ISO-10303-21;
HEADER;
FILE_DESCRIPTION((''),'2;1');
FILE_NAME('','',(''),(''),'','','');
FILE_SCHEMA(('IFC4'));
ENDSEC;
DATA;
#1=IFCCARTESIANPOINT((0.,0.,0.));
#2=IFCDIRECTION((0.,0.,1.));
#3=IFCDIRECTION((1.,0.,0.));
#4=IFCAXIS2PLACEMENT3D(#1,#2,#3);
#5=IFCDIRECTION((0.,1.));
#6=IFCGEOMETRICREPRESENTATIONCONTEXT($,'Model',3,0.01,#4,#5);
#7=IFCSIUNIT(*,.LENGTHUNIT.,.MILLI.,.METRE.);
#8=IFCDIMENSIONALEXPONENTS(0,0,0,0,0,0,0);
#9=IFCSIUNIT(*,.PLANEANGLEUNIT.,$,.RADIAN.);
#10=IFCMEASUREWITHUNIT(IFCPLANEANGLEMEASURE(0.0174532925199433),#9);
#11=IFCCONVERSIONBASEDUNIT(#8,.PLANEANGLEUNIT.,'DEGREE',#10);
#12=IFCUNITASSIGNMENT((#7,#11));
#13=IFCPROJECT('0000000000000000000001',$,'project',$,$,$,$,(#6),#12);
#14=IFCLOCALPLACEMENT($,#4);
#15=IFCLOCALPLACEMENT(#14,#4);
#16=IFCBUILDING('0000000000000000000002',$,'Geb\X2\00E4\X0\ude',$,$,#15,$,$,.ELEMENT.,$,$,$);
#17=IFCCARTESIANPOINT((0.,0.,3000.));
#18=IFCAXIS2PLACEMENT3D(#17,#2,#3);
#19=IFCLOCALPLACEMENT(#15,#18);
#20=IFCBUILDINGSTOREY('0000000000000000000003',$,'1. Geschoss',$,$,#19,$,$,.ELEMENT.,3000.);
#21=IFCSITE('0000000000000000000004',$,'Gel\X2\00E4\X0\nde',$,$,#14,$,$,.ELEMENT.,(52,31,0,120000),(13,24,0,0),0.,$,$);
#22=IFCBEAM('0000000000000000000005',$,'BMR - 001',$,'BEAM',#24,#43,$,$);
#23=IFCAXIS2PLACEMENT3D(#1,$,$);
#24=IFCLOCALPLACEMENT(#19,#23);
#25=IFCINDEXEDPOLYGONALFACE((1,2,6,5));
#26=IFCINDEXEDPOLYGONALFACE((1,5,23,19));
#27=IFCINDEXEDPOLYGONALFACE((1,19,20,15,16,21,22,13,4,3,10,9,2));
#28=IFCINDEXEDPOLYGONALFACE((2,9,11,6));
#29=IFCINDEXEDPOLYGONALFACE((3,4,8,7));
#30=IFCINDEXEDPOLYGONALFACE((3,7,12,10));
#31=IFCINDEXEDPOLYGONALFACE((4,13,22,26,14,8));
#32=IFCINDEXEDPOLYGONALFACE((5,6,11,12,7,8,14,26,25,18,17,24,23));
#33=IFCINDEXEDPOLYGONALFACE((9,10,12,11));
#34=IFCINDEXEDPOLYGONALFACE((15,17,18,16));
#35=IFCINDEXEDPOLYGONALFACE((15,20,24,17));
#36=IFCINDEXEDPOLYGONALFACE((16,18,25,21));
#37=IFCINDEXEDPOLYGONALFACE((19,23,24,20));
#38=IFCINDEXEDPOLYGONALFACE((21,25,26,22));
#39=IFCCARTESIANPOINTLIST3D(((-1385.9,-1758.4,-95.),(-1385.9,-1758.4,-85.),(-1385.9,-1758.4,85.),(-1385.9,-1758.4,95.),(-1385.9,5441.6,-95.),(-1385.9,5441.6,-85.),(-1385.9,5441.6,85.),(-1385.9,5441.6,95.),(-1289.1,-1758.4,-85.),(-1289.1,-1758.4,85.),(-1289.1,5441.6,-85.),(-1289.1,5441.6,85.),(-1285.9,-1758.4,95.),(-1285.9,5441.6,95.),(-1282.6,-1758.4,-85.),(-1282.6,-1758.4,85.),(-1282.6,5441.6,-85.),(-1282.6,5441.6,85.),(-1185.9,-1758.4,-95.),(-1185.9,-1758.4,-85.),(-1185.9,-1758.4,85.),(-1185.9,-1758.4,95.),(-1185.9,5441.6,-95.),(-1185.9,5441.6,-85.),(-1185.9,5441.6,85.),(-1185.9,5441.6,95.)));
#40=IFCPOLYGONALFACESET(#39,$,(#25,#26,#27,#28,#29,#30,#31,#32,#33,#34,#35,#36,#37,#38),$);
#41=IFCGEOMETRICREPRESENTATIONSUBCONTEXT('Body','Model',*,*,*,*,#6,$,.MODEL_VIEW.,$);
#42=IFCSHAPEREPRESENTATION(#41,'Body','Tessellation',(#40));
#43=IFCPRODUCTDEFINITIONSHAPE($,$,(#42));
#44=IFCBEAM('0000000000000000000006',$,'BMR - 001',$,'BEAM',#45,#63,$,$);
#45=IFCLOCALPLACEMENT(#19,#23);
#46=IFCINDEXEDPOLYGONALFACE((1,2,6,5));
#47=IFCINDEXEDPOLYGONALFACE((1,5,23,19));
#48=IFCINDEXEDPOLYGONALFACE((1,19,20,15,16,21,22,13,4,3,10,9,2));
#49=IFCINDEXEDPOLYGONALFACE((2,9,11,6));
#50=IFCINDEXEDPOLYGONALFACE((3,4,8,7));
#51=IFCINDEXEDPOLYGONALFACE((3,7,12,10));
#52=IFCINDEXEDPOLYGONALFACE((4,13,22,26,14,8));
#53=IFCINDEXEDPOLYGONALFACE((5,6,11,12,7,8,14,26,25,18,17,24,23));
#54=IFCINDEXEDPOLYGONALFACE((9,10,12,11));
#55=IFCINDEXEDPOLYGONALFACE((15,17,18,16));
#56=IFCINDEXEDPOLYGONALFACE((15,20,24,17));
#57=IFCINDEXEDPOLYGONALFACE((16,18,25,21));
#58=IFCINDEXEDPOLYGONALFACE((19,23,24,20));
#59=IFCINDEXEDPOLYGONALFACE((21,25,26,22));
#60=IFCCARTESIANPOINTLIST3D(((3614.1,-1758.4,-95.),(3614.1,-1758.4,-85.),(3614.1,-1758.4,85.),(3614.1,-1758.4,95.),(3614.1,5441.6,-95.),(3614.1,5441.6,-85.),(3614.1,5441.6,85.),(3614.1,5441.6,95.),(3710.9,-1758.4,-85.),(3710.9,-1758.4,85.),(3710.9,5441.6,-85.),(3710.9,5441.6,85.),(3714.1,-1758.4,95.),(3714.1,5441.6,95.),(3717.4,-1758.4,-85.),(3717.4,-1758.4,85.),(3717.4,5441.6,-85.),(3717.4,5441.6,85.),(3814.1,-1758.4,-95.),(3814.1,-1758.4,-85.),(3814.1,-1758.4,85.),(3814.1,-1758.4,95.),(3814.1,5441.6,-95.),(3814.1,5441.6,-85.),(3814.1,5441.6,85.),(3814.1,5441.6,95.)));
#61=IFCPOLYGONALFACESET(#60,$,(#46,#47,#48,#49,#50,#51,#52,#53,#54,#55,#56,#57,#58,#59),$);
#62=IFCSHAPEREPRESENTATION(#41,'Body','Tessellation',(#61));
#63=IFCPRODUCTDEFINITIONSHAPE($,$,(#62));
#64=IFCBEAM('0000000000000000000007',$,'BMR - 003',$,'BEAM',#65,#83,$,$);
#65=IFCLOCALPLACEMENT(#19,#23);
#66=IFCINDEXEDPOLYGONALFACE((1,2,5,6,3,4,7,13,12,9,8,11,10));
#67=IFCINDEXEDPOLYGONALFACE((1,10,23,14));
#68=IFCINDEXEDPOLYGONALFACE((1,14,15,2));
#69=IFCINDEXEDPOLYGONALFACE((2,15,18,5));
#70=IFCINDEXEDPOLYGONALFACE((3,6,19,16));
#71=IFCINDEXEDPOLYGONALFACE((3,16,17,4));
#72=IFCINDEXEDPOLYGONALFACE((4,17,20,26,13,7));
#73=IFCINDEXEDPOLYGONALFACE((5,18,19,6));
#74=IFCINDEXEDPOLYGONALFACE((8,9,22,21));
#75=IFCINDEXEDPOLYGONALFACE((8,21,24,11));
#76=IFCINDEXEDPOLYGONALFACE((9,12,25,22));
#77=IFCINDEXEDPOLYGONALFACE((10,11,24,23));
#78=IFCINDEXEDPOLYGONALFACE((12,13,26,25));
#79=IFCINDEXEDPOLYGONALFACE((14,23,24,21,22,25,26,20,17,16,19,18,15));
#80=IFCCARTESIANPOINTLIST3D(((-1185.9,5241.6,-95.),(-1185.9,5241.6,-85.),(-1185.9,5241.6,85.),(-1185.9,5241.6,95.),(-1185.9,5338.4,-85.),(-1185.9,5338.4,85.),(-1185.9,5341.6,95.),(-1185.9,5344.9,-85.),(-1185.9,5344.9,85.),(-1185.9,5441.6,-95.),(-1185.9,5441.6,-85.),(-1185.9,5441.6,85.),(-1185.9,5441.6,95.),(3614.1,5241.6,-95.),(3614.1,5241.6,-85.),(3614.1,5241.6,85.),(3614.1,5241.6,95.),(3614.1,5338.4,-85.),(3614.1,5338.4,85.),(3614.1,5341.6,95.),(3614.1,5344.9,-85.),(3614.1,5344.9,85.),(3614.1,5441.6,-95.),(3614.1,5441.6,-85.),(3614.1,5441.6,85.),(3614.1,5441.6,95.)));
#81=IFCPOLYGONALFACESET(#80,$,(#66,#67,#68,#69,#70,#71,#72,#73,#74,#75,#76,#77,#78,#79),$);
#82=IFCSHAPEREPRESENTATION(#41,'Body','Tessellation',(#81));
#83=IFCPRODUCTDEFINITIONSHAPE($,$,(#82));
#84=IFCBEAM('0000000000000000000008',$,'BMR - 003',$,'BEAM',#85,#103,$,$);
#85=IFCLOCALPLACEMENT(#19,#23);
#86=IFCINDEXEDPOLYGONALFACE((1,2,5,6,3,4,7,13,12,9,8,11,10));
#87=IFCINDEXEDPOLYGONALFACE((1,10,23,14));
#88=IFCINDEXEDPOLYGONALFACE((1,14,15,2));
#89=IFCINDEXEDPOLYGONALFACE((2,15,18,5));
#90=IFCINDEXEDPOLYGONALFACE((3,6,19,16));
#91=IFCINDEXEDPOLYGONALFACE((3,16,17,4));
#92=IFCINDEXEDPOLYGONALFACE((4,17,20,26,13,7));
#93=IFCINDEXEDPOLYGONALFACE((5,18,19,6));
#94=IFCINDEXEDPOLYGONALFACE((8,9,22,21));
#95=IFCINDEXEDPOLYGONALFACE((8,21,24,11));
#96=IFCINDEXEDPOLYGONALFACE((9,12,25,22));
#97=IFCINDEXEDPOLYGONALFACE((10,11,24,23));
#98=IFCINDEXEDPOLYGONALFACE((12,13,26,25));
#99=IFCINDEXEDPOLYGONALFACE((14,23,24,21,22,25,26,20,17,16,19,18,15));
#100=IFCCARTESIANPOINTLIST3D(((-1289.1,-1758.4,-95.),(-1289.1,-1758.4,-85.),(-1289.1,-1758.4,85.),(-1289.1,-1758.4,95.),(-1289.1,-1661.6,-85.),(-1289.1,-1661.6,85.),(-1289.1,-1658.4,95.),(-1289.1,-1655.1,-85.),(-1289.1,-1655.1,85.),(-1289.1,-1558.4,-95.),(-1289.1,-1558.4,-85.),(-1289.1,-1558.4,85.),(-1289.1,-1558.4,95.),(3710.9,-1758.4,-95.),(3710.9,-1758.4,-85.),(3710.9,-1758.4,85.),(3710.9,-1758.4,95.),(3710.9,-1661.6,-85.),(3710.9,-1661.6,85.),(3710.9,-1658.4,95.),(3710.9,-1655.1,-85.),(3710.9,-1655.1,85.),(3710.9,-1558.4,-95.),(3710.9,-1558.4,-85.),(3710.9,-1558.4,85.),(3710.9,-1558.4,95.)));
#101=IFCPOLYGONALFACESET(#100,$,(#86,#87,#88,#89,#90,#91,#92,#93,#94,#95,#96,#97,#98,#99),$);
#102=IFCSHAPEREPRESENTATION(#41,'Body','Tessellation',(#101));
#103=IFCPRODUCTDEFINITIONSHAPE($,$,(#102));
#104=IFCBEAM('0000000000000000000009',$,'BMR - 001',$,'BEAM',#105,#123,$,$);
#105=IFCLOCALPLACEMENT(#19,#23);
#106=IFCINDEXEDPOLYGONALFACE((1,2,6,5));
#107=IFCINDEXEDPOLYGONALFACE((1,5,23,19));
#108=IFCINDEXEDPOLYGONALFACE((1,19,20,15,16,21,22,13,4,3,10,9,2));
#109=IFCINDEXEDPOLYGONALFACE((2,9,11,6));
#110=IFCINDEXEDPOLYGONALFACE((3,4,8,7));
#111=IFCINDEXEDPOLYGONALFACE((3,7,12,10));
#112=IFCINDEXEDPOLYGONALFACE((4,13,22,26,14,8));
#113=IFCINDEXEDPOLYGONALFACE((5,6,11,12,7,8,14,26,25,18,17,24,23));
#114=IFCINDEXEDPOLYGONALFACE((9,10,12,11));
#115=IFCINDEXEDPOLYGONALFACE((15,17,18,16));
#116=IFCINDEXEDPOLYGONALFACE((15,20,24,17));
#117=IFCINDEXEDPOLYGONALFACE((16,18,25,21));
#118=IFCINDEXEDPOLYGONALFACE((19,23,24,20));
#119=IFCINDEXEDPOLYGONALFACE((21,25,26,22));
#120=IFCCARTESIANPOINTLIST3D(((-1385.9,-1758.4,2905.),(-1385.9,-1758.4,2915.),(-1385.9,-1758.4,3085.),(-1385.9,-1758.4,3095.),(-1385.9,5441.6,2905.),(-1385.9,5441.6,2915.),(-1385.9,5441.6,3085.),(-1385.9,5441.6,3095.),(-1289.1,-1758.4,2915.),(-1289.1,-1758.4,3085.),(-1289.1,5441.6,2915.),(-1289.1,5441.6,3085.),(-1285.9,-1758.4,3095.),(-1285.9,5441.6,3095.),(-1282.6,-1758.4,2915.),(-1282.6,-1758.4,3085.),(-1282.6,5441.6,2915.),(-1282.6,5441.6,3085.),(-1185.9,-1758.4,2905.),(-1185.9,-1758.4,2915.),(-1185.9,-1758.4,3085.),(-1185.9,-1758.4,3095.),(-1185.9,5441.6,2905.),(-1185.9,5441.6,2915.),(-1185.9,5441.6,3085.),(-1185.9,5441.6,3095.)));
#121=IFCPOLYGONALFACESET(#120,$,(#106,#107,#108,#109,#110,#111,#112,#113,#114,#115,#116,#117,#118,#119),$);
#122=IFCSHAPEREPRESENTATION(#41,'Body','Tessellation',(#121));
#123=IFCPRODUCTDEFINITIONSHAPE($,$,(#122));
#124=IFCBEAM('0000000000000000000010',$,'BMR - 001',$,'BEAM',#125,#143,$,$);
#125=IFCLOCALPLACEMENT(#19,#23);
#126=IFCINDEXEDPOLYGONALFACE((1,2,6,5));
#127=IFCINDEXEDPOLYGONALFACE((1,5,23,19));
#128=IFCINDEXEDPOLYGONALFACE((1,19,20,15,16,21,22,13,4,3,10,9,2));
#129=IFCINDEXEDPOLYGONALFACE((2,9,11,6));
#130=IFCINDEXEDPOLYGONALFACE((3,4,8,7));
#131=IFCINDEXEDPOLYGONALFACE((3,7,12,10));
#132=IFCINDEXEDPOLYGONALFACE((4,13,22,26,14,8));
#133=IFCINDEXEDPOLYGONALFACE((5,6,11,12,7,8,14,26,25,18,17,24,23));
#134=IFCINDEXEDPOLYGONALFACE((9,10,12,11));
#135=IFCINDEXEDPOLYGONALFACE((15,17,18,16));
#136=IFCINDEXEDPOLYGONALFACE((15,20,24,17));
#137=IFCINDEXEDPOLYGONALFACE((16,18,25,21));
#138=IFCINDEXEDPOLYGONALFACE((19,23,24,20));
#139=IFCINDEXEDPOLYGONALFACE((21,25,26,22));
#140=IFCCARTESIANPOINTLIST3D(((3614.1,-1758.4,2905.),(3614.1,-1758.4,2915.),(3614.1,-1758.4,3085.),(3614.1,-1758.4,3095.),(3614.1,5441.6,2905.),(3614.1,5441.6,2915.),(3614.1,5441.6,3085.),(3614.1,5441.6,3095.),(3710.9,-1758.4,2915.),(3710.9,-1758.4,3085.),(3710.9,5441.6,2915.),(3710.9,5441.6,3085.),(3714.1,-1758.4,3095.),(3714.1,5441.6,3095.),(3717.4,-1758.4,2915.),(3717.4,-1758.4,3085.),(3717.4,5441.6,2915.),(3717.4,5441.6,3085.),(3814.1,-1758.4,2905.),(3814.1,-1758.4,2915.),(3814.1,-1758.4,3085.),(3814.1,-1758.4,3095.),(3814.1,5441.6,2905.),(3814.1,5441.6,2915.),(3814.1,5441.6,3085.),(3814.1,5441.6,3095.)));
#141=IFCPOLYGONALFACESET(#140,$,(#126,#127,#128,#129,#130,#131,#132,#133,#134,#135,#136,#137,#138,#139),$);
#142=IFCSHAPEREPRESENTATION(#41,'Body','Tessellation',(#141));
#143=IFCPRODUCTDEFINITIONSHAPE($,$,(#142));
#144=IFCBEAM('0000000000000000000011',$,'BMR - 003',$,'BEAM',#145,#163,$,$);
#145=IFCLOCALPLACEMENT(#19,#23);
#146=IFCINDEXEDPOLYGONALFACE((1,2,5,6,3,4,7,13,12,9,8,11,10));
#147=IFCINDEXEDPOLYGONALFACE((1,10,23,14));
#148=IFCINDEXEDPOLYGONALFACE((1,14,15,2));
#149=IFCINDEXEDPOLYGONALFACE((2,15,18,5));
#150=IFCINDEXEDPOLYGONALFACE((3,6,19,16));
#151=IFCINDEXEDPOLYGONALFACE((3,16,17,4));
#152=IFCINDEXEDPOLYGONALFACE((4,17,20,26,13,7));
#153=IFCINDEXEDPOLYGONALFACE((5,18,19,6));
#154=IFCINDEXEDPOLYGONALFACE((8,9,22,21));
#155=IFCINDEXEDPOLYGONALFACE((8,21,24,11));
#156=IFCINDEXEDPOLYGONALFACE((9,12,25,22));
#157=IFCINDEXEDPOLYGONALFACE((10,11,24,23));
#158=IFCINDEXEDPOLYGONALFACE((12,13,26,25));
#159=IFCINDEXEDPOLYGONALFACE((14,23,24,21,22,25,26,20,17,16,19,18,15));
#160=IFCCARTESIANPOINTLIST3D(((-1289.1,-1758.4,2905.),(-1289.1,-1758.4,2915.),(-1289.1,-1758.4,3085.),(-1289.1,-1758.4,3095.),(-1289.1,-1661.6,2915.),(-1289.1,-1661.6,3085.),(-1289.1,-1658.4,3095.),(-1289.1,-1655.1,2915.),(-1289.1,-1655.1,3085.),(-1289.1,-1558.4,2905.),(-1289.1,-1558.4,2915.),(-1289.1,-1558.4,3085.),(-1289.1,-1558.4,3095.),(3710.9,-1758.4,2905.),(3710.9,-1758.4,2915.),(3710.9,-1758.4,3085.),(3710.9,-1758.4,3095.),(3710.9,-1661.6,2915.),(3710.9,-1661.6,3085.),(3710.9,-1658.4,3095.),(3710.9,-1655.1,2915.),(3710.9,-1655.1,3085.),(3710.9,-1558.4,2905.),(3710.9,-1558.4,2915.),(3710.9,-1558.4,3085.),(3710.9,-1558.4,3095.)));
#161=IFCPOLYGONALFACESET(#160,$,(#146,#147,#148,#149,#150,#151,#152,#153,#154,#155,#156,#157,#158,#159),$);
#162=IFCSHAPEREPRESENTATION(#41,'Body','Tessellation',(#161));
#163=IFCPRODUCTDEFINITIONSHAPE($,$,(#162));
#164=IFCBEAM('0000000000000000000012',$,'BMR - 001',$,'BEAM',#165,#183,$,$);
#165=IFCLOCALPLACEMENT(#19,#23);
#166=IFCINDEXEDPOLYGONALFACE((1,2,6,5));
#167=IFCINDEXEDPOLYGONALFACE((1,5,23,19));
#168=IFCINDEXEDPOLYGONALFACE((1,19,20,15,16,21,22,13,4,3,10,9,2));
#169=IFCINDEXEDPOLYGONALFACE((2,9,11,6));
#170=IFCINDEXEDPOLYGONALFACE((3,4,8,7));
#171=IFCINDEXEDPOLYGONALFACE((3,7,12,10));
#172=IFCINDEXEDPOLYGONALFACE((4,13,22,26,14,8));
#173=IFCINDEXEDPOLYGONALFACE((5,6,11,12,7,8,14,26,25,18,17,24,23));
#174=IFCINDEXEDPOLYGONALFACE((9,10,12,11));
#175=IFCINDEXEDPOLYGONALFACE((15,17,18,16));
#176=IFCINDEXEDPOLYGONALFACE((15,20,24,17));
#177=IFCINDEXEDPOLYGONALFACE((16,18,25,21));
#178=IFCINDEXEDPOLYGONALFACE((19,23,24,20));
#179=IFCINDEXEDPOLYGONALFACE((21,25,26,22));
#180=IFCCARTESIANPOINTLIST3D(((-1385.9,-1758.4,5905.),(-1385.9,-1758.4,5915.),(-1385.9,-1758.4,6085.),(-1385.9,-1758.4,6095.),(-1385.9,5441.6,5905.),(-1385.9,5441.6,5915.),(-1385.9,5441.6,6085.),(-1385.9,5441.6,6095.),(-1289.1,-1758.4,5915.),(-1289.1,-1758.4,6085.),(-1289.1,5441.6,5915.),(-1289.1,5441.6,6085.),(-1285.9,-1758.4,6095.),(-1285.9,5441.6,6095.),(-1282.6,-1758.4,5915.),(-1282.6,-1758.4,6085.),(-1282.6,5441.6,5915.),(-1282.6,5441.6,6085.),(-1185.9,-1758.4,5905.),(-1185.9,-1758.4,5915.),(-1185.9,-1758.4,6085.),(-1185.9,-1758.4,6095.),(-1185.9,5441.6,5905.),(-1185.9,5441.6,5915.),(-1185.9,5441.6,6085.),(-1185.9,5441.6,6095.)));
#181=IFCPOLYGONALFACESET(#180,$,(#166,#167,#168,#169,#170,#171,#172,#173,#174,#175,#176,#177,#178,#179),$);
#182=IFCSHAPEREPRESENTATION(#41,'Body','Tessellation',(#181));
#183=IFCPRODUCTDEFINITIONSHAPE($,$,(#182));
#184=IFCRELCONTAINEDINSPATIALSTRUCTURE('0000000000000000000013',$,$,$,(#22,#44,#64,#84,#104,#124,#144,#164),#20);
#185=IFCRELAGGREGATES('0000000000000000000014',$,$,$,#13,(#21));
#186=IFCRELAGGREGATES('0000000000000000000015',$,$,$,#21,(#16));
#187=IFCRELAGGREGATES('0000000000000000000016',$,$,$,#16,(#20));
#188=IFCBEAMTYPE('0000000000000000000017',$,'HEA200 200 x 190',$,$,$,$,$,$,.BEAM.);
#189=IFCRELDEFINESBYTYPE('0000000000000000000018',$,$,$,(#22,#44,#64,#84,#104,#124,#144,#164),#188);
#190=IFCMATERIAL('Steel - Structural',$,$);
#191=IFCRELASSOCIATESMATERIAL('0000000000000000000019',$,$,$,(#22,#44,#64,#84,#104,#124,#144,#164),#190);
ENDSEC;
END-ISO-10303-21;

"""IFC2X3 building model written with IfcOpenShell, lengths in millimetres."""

from ifc_helpers import new_model, entity, si_unit, converted_unit, direction, frame, origin_with_axes, place, context, subcontext, project, spatial, polyline, outline, extrude, material, type_object, element, save


model = new_model("IFC2X3")

# Units and contexts
model_context = context("Model", 3, precision=0.01, world=origin_with_axes(), true_north=direction((0.0, 1.0)))
body_context = subcontext(model_context, "Body", "Model", "MODEL_VIEW")
ifc_project = project(units=[si_unit("LENGTHUNIT", "METRE", prefix="MILLI"), converted_unit("PLANEANGLEUNIT", "DEGREE", entity("IfcPlaneAngleMeasure", 0.0174532925199433), si_unit("PLANEANGLEUNIT", "RADIAN"), dimensions=[0, 0, 0, 0, 0, 0, 0])], contexts=[model_context])

# Site, building, storey
site_placement = place(None, origin_with_axes())
site = spatial("IfcSite", under=ifc_project, at=site_placement, Name="Gelände", CompositionType="ELEMENT", RefLatitude=(52, 31, 0, 120000), RefLongitude=(13, 24, 0, 0), RefElevation=0.0)
building_placement = place(site_placement, origin_with_axes())
building = spatial("IfcBuilding", under=site, at=building_placement, Name="Gebäude", CompositionType="ELEMENT")
storey_placement = place(building_placement, frame((0.0, 0.0, 3000.0), z_axis=(0.0, 0.0, 1.0), x_axis=(1.0, 0.0, 0.0)))
storey = spatial("IfcBuildingStorey", under=building, at=storey_placement, Name="1. Geschoss", CompositionType="ELEMENT", Elevation=3000.0)

# Beams
ifc_material = material(Name="Steel - Structural")
beam_type = type_object("IfcBeamType", Name="HEA200 200 x 190", PredefinedType="BEAM")
for number, where, z_axis, x_axis, name in (
    (1, (-1285.9, -1758.4, 0.0), (0.0, 0.0, 1.0), (1.0, 0.0, 0.0), "BMR - 001"),
    (2, (3714.1, -1758.4, 0.0), (0.0, 0.0, 1.0), (1.0, 0.0, 0.0), "BMR - 001"),
):
    element("IfcBeam", number, at=place(storey_placement, frame(where, z_axis=z_axis, x_axis=x_axis)), inside=storey, type_object=beam_type, material=ifc_material, Name=name, ObjectType="BEAM", context=body_context, shape_type="SweptSolid", body=[
        extrude(outline(polyline([(0.0, 95.0), (-100.0, 95.0), (-100.0, 85.0), (-3.2, 85.0), (-3.2, -85.0), (-100.0, -85.0), (-100.0, -95.0), (100.0, -95.0), (100.0, -85.0), (3.2, -85.0), (3.2, 85.0), (100.0, 85.0), (100.0, 95.0), (0.0, 95.0)])), frame((0.0, 7200.0, 0.0), z_axis=(0.0, -1.0, 0.0), x_axis=(1.0, 0.0, 0.0)), (0.0, 0.0, 1.0), 7200.0),
    ])
beam_1_placement = place(storey_placement, frame((-1185.9, 5341.6, 0.0), z_axis=(0.0, 0.0, 1.0), x_axis=(0.0, -1.0, 0.0)))
element("IfcBeam", 3, at=beam_1_placement, inside=storey, type_object=beam_type, material=ifc_material, Name="BMR - 003", ObjectType="BEAM", context=body_context, shape_type="SweptSolid", body=[
    extrude(outline(polyline([(0.0, 95.0), (-100.0, 95.0), (-100.0, 85.0), (-3.2, 85.0), (-3.2, -85.0), (-100.0, -85.0), (-100.0, -95.0), (100.0, -95.0), (100.0, -85.0), (3.2, -85.0), (3.2, 85.0), (100.0, 85.0), (100.0, 95.0), (0.0, 95.0)])), frame((0.0, 4800.0, 0.0), z_axis=(0.0, -1.0, 0.0), x_axis=(1.0, 0.0, 0.0)), (0.0, 0.0, 1.0), 4800.0),
])
beam_2_placement = place(storey_placement, frame((-1289.1, -1658.4, 0.0), z_axis=(0.0, 0.0, 1.0), x_axis=(0.0, -1.0, 0.0)))
element("IfcBeam", 4, at=beam_2_placement, inside=storey, type_object=beam_type, material=ifc_material, Name="BMR - 003", ObjectType="BEAM", context=body_context, shape_type="SweptSolid", body=[
    extrude(outline(polyline([(0.0, 95.0), (-100.0, 95.0), (-100.0, 85.0), (-3.2, 85.0), (-3.2, -85.0), (-100.0, -85.0), (-100.0, -95.0), (100.0, -95.0), (100.0, -85.0), (3.2, -85.0), (3.2, 85.0), (100.0, 85.0), (100.0, 95.0), (0.0, 95.0)])), frame((0.0, 5000.0, 0.0), z_axis=(0.0, -1.0, 0.0), x_axis=(1.0, 0.0, 0.0)), (0.0, 0.0, 1.0), 5000.0),
])
for number, where, z_axis, x_axis, name in (
    (5, (-1285.9, -1758.4, 3000.0), (0.0, 0.0, 1.0), (1.0, 0.0, 0.0), "BMR - 001"),
    (6, (3714.1, -1758.4, 3000.0), (0.0, 0.0, 1.0), (1.0, 0.0, 0.0), "BMR - 001"),
):
    element("IfcBeam", number, at=place(storey_placement, frame(where, z_axis=z_axis, x_axis=x_axis)), inside=storey, type_object=beam_type, material=ifc_material, Name=name, ObjectType="BEAM", context=body_context, shape_type="SweptSolid", body=[
        extrude(outline(polyline([(0.0, 95.0), (-100.0, 95.0), (-100.0, 85.0), (-3.2, 85.0), (-3.2, -85.0), (-100.0, -85.0), (-100.0, -95.0), (100.0, -95.0), (100.0, -85.0), (3.2, -85.0), (3.2, 85.0), (100.0, 85.0), (100.0, 95.0), (0.0, 95.0)])), frame((0.0, 7200.0, 0.0), z_axis=(0.0, -1.0, 0.0), x_axis=(1.0, 0.0, 0.0)), (0.0, 0.0, 1.0), 7200.0),
    ])
beam_3_placement = place(storey_placement, frame((-1289.1, -1658.4, 3000.0), z_axis=(0.0, 0.0, 1.0), x_axis=(0.0, -1.0, 0.0)))
element("IfcBeam", 7, at=beam_3_placement, inside=storey, type_object=beam_type, material=ifc_material, Name="BMR - 003", ObjectType="BEAM", context=body_context, shape_type="SweptSolid", body=[
    extrude(outline(polyline([(0.0, 95.0), (-100.0, 95.0), (-100.0, 85.0), (-3.2, 85.0), (-3.2, -85.0), (-100.0, -85.0), (-100.0, -95.0), (100.0, -95.0), (100.0, -85.0), (3.2, -85.0), (3.2, 85.0), (100.0, 85.0), (100.0, 95.0), (0.0, 95.0)])), frame((0.0, 5000.0, 0.0), z_axis=(0.0, -1.0, 0.0), x_axis=(1.0, 0.0, 0.0)), (0.0, 0.0, 1.0), 5000.0),
])
for number, where, z_axis, x_axis, name in (
    (8, (-1285.9, -1758.4, 6000.0), (0.0, 0.0, 1.0), (1.0, 0.0, 0.0), "BMR - 001"),
):
    element("IfcBeam", number, at=place(storey_placement, frame(where, z_axis=z_axis, x_axis=x_axis)), inside=storey, type_object=beam_type, material=ifc_material, Name=name, ObjectType="BEAM", context=body_context, shape_type="SweptSolid", body=[
        extrude(outline(polyline([(0.0, 95.0), (-100.0, 95.0), (-100.0, 85.0), (-3.2, 85.0), (-3.2, -85.0), (-100.0, -85.0), (-100.0, -95.0), (100.0, -95.0), (100.0, -85.0), (3.2, -85.0), (3.2, 85.0), (100.0, 85.0), (100.0, 95.0), (0.0, 95.0)])), frame((0.0, 7200.0, 0.0), z_axis=(0.0, -1.0, 0.0), x_axis=(1.0, 0.0, 0.0)), (0.0, 0.0, 1.0), 7200.0),
    ])

save(model, "model.ifc")
